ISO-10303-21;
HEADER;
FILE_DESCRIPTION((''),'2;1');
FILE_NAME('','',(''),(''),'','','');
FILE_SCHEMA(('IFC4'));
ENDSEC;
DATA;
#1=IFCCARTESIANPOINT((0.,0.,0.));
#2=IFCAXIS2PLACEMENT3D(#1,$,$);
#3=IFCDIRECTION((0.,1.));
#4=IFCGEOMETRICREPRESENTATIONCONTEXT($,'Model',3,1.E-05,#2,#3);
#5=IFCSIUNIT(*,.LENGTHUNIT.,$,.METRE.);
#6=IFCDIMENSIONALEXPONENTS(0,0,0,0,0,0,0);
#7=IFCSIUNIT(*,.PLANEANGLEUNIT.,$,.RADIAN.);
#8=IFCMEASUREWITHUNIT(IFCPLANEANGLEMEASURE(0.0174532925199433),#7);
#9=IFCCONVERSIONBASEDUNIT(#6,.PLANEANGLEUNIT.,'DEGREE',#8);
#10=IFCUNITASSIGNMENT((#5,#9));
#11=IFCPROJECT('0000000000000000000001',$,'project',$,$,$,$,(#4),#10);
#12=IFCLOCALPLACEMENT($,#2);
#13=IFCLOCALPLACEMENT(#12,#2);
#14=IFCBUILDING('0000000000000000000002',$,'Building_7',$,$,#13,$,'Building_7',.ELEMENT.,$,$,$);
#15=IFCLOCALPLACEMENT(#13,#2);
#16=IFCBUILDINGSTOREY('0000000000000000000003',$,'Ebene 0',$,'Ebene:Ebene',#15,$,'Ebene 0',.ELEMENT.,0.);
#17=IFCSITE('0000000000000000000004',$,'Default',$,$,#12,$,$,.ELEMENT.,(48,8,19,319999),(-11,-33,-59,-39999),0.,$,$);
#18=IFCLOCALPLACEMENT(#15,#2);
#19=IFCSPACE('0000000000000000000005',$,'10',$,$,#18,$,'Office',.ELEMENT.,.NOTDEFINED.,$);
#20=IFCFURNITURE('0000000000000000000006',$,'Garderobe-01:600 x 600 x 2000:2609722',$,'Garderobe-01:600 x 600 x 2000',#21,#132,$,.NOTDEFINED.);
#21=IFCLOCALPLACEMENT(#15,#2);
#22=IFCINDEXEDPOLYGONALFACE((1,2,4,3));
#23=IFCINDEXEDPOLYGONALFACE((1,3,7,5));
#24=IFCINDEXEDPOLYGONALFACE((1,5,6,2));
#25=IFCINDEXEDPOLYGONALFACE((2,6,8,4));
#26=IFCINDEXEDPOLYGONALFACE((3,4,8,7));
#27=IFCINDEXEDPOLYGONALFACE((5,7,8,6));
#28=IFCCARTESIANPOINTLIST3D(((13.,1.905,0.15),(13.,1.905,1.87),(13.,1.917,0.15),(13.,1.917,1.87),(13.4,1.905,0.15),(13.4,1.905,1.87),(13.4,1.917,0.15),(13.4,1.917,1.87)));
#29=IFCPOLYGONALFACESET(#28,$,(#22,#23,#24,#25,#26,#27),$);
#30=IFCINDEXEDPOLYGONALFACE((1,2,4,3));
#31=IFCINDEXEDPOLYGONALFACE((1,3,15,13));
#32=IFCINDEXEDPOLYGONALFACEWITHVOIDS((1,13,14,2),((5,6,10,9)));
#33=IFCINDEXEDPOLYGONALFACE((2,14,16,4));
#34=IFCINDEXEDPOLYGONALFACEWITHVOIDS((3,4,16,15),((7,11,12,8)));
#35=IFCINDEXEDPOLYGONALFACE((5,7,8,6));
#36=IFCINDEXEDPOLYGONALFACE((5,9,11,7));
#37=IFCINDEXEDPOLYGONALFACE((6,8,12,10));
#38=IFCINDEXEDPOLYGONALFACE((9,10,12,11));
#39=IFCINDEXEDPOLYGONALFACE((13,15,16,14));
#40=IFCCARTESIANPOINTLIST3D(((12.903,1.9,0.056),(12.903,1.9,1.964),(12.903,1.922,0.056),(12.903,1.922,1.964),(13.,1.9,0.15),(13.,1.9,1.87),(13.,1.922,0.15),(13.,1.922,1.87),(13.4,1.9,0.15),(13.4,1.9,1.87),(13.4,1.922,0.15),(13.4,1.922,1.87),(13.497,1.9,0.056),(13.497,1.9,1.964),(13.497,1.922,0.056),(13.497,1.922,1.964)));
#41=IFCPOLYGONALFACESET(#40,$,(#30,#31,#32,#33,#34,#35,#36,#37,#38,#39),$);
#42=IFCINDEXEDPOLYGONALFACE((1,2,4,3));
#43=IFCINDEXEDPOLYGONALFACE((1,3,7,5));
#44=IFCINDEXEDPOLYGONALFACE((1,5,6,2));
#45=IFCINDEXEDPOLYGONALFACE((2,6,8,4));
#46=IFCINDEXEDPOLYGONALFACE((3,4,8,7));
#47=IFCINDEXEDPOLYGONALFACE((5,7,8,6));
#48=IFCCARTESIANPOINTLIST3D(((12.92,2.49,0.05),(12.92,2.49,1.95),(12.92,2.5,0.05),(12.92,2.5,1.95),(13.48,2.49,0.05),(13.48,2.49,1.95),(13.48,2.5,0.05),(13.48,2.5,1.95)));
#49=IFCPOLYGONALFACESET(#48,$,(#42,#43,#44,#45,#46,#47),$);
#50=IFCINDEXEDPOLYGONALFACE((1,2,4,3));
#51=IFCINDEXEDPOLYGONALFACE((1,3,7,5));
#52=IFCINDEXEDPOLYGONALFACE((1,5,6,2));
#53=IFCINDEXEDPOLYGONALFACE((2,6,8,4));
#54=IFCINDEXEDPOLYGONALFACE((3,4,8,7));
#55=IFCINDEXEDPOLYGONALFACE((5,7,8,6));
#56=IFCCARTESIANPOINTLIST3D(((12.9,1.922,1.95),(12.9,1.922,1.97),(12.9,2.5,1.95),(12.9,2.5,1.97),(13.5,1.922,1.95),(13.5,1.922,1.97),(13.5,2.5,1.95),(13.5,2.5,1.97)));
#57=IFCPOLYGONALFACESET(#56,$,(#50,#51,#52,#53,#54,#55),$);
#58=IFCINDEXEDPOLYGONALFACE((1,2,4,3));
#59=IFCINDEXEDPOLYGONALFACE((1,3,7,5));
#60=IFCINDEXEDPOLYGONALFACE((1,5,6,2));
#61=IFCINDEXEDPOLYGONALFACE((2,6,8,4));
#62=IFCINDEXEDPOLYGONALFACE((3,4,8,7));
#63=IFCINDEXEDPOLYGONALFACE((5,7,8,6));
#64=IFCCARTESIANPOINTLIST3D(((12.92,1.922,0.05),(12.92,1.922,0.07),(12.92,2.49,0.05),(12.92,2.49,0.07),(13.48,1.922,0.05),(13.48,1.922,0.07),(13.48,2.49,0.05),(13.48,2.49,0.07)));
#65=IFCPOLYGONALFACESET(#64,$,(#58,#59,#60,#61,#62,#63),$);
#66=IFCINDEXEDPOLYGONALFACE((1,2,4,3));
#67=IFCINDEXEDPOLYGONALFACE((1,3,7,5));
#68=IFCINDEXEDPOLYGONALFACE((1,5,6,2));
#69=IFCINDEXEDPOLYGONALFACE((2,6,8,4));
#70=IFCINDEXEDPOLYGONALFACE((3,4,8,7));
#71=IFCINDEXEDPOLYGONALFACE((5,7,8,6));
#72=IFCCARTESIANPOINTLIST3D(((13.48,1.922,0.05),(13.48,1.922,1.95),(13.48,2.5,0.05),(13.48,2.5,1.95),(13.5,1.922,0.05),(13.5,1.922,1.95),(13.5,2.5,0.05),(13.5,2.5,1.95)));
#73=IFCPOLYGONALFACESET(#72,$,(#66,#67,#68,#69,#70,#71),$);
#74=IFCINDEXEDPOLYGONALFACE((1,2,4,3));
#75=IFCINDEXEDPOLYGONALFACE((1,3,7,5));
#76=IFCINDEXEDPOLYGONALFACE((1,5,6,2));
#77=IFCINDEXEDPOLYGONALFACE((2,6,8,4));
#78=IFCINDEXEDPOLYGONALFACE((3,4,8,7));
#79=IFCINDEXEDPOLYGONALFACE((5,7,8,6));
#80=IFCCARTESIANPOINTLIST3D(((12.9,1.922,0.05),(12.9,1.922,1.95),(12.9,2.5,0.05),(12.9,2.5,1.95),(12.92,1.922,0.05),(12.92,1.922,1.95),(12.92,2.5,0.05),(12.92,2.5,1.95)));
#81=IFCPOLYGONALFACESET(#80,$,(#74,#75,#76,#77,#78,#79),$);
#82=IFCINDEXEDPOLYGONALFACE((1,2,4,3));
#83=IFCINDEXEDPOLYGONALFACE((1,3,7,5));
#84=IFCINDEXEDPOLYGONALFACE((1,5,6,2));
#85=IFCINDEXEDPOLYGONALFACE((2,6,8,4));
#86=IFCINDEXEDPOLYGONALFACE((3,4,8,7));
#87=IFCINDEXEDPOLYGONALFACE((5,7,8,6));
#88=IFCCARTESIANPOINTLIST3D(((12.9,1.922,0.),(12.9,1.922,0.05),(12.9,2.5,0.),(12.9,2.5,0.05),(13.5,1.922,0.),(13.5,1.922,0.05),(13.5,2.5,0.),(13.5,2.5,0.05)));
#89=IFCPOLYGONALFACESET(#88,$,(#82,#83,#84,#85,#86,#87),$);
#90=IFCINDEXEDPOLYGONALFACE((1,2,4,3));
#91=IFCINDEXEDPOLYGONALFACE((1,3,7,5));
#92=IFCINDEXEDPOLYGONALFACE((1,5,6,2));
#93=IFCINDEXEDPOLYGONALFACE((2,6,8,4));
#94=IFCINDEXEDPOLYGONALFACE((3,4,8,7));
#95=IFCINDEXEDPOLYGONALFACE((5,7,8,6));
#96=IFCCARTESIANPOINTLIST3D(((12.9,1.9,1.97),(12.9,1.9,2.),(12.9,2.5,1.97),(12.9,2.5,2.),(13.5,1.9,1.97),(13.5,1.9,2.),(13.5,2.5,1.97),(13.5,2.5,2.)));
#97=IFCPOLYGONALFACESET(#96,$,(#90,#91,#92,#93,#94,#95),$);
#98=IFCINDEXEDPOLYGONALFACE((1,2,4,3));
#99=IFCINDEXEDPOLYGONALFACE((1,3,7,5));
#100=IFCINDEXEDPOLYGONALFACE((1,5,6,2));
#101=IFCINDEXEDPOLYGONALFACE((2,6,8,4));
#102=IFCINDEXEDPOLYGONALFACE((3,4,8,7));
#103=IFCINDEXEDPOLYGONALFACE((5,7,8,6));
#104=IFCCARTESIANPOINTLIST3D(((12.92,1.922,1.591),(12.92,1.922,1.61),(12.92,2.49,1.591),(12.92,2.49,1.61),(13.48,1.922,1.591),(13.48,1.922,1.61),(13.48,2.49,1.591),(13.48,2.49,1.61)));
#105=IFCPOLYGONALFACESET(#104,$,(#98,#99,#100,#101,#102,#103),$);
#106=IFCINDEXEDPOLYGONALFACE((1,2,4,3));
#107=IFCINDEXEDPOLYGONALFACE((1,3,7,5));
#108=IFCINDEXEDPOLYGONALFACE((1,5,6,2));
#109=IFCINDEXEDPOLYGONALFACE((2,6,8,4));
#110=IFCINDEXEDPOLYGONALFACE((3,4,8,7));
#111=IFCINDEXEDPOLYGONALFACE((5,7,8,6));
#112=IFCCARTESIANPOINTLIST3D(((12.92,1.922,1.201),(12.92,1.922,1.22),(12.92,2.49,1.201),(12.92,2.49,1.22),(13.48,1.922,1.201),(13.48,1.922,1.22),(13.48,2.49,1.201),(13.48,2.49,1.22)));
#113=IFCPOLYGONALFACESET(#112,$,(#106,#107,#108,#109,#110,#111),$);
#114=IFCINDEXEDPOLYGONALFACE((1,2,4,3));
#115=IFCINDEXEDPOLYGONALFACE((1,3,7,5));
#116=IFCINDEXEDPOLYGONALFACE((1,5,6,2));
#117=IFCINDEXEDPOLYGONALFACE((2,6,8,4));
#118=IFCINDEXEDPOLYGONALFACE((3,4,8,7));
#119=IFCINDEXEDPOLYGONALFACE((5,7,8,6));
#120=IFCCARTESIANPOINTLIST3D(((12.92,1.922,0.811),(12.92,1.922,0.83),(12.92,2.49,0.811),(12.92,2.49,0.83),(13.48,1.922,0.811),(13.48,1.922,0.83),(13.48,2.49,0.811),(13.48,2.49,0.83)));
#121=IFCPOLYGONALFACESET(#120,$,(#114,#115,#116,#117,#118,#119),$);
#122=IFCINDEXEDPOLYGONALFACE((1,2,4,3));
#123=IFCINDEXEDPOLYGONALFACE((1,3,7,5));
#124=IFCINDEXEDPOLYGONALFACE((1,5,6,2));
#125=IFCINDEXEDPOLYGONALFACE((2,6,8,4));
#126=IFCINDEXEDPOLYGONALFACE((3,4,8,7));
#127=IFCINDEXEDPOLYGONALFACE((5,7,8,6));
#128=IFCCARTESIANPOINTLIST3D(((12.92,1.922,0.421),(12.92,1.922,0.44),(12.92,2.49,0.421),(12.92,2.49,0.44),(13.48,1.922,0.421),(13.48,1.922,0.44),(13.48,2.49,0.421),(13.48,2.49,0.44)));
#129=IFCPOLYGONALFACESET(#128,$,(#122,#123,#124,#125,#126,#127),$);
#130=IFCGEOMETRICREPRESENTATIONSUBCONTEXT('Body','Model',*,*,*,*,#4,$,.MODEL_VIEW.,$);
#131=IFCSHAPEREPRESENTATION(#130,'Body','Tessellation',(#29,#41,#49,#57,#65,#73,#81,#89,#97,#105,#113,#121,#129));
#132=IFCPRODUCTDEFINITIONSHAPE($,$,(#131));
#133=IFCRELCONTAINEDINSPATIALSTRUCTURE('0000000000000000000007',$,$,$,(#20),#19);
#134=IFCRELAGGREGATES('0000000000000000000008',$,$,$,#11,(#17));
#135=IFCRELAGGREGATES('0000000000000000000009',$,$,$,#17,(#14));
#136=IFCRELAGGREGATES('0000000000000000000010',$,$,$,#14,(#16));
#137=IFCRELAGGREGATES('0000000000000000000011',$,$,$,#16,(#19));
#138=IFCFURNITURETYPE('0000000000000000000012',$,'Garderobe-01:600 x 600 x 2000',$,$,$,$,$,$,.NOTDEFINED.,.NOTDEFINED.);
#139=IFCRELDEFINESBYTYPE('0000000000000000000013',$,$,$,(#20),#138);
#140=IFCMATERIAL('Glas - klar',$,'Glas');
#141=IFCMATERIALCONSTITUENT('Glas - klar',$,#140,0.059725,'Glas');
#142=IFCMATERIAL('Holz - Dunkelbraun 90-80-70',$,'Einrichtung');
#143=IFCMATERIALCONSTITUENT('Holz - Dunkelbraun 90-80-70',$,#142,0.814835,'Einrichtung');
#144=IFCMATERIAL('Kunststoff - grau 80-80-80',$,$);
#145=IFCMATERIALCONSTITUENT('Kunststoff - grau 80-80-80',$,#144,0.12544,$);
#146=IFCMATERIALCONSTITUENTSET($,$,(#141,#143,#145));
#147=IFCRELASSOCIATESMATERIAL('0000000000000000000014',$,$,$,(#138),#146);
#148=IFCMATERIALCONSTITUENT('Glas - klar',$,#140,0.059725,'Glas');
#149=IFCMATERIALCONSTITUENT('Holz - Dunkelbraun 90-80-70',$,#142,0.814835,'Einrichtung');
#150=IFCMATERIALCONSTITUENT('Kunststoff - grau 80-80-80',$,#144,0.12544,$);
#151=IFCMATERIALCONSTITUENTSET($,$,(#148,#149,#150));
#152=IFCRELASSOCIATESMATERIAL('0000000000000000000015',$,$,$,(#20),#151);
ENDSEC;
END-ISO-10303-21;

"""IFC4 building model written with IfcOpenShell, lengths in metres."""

from ifc_helpers import new_model, entity, si_unit, converted_unit, direction, frame, origin, place, context, subcontext, project, spatial, indexed_curve, outline, extrude, source, transform, mapped, material, constituent, constituent_set, type_object, type_shapes, element, save


model = new_model("IFC4")

# Units and contexts
model_context = context("Model", 3, precision=1e-05, world=origin(), true_north=direction((0.0, 1.0)))
body_context = subcontext(model_context, "Body", "Model", "MODEL_VIEW")
ifc_project = project(units=[si_unit("LENGTHUNIT", "METRE"), converted_unit("PLANEANGLEUNIT", "DEGREE", entity("IfcPlaneAngleMeasure", 0.0174532925199433), si_unit("PLANEANGLEUNIT", "RADIAN"), dimensions=[0, 0, 0, 0, 0, 0, 0])], contexts=[model_context])

# Site, building, storey
site_placement = place(None, origin())
site = spatial("IfcSite", under=ifc_project, at=site_placement, Name="Default", CompositionType="ELEMENT", RefLatitude=(48, 8, 19, 319999), RefLongitude=(-11, -33, -59, -39999), RefElevation=0.0)
building_placement = place(site_placement, origin())
building = spatial("IfcBuilding", under=site, at=building_placement, Name="Building_7", LongName="Building_7", CompositionType="ELEMENT")
storey_placement = place(building_placement, origin())
storey = spatial("IfcBuildingStorey", under=building, at=storey_placement, Name="Ebene 0", ObjectType="Ebene:Ebene", LongName="Ebene 0", CompositionType="ELEMENT", Elevation=0.0)

# Shared definitions
ifc_material_1 = material(Name="Glas - klar", Category="Glas")
ifc_material_2 = material(Name="Holz - Dunkelbraun 90-80-70", Category="Einrichtung")
ifc_material_3 = material(Name="Kunststoff - grau 80-80-80")
ifc_constituent_1 = constituent(ifc_material_1, Name="Glas - klar", Category="Glas", fraction=0.059725)
ifc_constituent_2 = constituent(ifc_material_2, Name="Holz - Dunkelbraun 90-80-70", Category="Einrichtung", fraction=0.814835)
ifc_constituent_3 = constituent(ifc_material_3, Name="Kunststoff - grau 80-80-80", fraction=0.12544)
ifc_constituent_set_1 = constituent_set(constituents=[ifc_constituent_1, ifc_constituent_2, ifc_constituent_3])
furniture_type_1 = type_object("IfcFurnitureType", Name="Garderobe-01:600 x 600 x 2000", AssemblyPlace="NOTDEFINED", PredefinedType="NOTDEFINED", material=ifc_constituent_set_1)
shared_shape_1 = source(origin(), body_context, "Body", "SweptSolid", [
    extrude(outline(indexed_curve([(-0.006, -0.2), (0.006, -0.2), (0.006, 0.2), (-0.006, 0.2), (-0.006, -0.2)], self_intersect=False)), frame((0.0, -0.289, 0.15), z_axis=(0.0, 0.0, 1.0), x_axis=(0.0, 1.0, 0.0)), (0.0, 0.0, 1.0), 1.72),
    extrude(outline(indexed_curve([(-0.954, -0.297), (0.954, -0.297), (0.954, 0.297), (-0.954, 0.297), (-0.954, -0.297)], self_intersect=False), holes=[indexed_curve([(-0.86, 0.2), (0.86, 0.2), (0.86, -0.2), (-0.86, -0.2), (-0.86, 0.2)], self_intersect=False)]), frame((0.0, -0.3, 1.01), z_axis=(0.0, 1.0, 0.0), x_axis=(0.0, 0.0, -1.0)), (0.0, 0.0, 1.0), 0.022),
    extrude(outline(indexed_curve([(-0.28, -0.005), (0.28, -0.005), (0.28, 0.005), (-0.28, 0.005), (-0.28, -0.005)], self_intersect=False)), frame((0.0, 0.295, 0.05), z_axis=(0.0, 0.0, 1.0), x_axis=(-1.0, 0.0, 0.0)), (0.0, 0.0, 1.0), 1.9),
    extrude(outline(indexed_curve([(-0.3, -0.289), (0.3, -0.289), (0.3, 0.289), (-0.3, 0.289), (-0.3, -0.289)], self_intersect=False)), frame((0.0, 0.011, 1.95), z_axis=(0.0, 0.0, 1.0), x_axis=(-1.0, 0.0, 0.0)), (0.0, 0.0, 1.0), 0.02),
    extrude(outline(indexed_curve([(-0.28, -0.284), (0.28, -0.284), (0.28, 0.284), (-0.28, 0.284), (-0.28, -0.284)], self_intersect=False)), frame((0.0, 0.006, 0.05), z_axis=(0.0, 0.0, 1.0), x_axis=(-1.0, 0.0, 0.0)), (0.0, 0.0, 1.0), 0.02),
    extrude(outline(indexed_curve([(-0.01, -0.289), (0.01, -0.289), (0.01, 0.289), (-0.01, 0.289), (-0.01, -0.289)], self_intersect=False)), frame((0.29, 0.011, 0.05), z_axis=(0.0, 0.0, 1.0), x_axis=(-1.0, 0.0, 0.0)), (0.0, 0.0, 1.0), 1.9),
    extrude(outline(indexed_curve([(-0.01, -0.289), (0.01, -0.289), (0.01, 0.289), (-0.01, 0.289), (-0.01, -0.289)], self_intersect=False)), frame((-0.29, 0.011, 0.05), z_axis=(0.0, 0.0, 1.0), x_axis=(-1.0, 0.0, 0.0)), (0.0, 0.0, 1.0), 1.9),
    extrude(outline(indexed_curve([(-0.3, -0.289), (0.3, -0.289), (0.3, 0.289), (-0.3, 0.289), (-0.3, -0.289)], self_intersect=False)), frame((0.0, 0.011, 0.0), z_axis=(0.0, 0.0, 1.0), x_axis=(-1.0, 0.0, 0.0)), (0.0, 0.0, 1.0), 0.05),
    extrude(outline(indexed_curve([(-0.3, -0.3), (0.3, -0.3), (0.3, 0.3), (-0.3, 0.3), (-0.3, -0.3)], self_intersect=False)), frame((0.0, 0.0, 1.97), z_axis=(0.0, 0.0, 1.0), x_axis=(-1.0, 0.0, 0.0)), (0.0, 0.0, 1.0), 0.03),
    extrude(outline(indexed_curve([(-0.28, -0.284), (0.28, -0.284), (0.28, 0.284), (-0.28, 0.284), (-0.28, -0.284)], self_intersect=False)), frame((0.0, 0.006, 1.591), z_axis=(0.0, 0.0, 1.0), x_axis=(-1.0, 0.0, 0.0)), (0.0, 0.0, 1.0), 0.019),
    extrude(outline(indexed_curve([(-0.28, -0.284), (0.28, -0.284), (0.28, 0.284), (-0.28, 0.284), (-0.28, -0.284)], self_intersect=False)), frame((0.0, 0.006, 1.201), z_axis=(0.0, 0.0, 1.0), x_axis=(-1.0, 0.0, 0.0)), (0.0, 0.0, 1.0), 0.019),
    extrude(outline(indexed_curve([(-0.28, -0.284), (0.28, -0.284), (0.28, 0.284), (-0.28, 0.284), (-0.28, -0.284)], self_intersect=False)), frame((0.0, 0.006, 0.811), z_axis=(0.0, 0.0, 1.0), x_axis=(-1.0, 0.0, 0.0)), (0.0, 0.0, 1.0), 0.019),
    extrude(outline(indexed_curve([(-0.28, -0.284), (0.28, -0.284), (0.28, 0.284), (-0.28, 0.284), (-0.28, -0.284)], self_intersect=False)), frame((0.0, 0.006, 0.421), z_axis=(0.0, 0.0, 1.0), x_axis=(-1.0, 0.0, 0.0)), (0.0, 0.0, 1.0), 0.019),
])
type_shapes(furniture_type_1, [shared_shape_1])

# Shared definitions
space_1_placement = place(storey_placement, origin())
space_1 = spatial("IfcSpace", under=storey, at=space_1_placement, Name="10", LongName="Office", CompositionType="ELEMENT", PredefinedType="NOTDEFINED")

# Furniture
ifc_constituent_4 = constituent(ifc_material_1, Name="Glas - klar", Category="Glas", fraction=0.059725)
ifc_constituent_5 = constituent(ifc_material_2, Name="Holz - Dunkelbraun 90-80-70", Category="Einrichtung", fraction=0.814835)
ifc_constituent_6 = constituent(ifc_material_3, Name="Kunststoff - grau 80-80-80", fraction=0.12544)
ifc_constituent_set_2 = constituent_set(constituents=[ifc_constituent_4, ifc_constituent_5, ifc_constituent_6])
furniture_1_placement = place(space_1_placement, frame((13.2, 2.2, 0.0)))
element("IfcFurniture", 1, at=furniture_1_placement, inside=space_1, type_object=furniture_type_1, material=ifc_constituent_set_2, Name="Garderobe-01:600 x 600 x 2000:2609722", ObjectType="Garderobe-01:600 x 600 x 2000", PredefinedType="NOTDEFINED", context=body_context, shape_type="MappedRepresentation", body=[
    mapped(shared_shape_1, transform((0.0, 0.0, 0.0), scale=1.0)),
])

save(model, "model.ifc")
